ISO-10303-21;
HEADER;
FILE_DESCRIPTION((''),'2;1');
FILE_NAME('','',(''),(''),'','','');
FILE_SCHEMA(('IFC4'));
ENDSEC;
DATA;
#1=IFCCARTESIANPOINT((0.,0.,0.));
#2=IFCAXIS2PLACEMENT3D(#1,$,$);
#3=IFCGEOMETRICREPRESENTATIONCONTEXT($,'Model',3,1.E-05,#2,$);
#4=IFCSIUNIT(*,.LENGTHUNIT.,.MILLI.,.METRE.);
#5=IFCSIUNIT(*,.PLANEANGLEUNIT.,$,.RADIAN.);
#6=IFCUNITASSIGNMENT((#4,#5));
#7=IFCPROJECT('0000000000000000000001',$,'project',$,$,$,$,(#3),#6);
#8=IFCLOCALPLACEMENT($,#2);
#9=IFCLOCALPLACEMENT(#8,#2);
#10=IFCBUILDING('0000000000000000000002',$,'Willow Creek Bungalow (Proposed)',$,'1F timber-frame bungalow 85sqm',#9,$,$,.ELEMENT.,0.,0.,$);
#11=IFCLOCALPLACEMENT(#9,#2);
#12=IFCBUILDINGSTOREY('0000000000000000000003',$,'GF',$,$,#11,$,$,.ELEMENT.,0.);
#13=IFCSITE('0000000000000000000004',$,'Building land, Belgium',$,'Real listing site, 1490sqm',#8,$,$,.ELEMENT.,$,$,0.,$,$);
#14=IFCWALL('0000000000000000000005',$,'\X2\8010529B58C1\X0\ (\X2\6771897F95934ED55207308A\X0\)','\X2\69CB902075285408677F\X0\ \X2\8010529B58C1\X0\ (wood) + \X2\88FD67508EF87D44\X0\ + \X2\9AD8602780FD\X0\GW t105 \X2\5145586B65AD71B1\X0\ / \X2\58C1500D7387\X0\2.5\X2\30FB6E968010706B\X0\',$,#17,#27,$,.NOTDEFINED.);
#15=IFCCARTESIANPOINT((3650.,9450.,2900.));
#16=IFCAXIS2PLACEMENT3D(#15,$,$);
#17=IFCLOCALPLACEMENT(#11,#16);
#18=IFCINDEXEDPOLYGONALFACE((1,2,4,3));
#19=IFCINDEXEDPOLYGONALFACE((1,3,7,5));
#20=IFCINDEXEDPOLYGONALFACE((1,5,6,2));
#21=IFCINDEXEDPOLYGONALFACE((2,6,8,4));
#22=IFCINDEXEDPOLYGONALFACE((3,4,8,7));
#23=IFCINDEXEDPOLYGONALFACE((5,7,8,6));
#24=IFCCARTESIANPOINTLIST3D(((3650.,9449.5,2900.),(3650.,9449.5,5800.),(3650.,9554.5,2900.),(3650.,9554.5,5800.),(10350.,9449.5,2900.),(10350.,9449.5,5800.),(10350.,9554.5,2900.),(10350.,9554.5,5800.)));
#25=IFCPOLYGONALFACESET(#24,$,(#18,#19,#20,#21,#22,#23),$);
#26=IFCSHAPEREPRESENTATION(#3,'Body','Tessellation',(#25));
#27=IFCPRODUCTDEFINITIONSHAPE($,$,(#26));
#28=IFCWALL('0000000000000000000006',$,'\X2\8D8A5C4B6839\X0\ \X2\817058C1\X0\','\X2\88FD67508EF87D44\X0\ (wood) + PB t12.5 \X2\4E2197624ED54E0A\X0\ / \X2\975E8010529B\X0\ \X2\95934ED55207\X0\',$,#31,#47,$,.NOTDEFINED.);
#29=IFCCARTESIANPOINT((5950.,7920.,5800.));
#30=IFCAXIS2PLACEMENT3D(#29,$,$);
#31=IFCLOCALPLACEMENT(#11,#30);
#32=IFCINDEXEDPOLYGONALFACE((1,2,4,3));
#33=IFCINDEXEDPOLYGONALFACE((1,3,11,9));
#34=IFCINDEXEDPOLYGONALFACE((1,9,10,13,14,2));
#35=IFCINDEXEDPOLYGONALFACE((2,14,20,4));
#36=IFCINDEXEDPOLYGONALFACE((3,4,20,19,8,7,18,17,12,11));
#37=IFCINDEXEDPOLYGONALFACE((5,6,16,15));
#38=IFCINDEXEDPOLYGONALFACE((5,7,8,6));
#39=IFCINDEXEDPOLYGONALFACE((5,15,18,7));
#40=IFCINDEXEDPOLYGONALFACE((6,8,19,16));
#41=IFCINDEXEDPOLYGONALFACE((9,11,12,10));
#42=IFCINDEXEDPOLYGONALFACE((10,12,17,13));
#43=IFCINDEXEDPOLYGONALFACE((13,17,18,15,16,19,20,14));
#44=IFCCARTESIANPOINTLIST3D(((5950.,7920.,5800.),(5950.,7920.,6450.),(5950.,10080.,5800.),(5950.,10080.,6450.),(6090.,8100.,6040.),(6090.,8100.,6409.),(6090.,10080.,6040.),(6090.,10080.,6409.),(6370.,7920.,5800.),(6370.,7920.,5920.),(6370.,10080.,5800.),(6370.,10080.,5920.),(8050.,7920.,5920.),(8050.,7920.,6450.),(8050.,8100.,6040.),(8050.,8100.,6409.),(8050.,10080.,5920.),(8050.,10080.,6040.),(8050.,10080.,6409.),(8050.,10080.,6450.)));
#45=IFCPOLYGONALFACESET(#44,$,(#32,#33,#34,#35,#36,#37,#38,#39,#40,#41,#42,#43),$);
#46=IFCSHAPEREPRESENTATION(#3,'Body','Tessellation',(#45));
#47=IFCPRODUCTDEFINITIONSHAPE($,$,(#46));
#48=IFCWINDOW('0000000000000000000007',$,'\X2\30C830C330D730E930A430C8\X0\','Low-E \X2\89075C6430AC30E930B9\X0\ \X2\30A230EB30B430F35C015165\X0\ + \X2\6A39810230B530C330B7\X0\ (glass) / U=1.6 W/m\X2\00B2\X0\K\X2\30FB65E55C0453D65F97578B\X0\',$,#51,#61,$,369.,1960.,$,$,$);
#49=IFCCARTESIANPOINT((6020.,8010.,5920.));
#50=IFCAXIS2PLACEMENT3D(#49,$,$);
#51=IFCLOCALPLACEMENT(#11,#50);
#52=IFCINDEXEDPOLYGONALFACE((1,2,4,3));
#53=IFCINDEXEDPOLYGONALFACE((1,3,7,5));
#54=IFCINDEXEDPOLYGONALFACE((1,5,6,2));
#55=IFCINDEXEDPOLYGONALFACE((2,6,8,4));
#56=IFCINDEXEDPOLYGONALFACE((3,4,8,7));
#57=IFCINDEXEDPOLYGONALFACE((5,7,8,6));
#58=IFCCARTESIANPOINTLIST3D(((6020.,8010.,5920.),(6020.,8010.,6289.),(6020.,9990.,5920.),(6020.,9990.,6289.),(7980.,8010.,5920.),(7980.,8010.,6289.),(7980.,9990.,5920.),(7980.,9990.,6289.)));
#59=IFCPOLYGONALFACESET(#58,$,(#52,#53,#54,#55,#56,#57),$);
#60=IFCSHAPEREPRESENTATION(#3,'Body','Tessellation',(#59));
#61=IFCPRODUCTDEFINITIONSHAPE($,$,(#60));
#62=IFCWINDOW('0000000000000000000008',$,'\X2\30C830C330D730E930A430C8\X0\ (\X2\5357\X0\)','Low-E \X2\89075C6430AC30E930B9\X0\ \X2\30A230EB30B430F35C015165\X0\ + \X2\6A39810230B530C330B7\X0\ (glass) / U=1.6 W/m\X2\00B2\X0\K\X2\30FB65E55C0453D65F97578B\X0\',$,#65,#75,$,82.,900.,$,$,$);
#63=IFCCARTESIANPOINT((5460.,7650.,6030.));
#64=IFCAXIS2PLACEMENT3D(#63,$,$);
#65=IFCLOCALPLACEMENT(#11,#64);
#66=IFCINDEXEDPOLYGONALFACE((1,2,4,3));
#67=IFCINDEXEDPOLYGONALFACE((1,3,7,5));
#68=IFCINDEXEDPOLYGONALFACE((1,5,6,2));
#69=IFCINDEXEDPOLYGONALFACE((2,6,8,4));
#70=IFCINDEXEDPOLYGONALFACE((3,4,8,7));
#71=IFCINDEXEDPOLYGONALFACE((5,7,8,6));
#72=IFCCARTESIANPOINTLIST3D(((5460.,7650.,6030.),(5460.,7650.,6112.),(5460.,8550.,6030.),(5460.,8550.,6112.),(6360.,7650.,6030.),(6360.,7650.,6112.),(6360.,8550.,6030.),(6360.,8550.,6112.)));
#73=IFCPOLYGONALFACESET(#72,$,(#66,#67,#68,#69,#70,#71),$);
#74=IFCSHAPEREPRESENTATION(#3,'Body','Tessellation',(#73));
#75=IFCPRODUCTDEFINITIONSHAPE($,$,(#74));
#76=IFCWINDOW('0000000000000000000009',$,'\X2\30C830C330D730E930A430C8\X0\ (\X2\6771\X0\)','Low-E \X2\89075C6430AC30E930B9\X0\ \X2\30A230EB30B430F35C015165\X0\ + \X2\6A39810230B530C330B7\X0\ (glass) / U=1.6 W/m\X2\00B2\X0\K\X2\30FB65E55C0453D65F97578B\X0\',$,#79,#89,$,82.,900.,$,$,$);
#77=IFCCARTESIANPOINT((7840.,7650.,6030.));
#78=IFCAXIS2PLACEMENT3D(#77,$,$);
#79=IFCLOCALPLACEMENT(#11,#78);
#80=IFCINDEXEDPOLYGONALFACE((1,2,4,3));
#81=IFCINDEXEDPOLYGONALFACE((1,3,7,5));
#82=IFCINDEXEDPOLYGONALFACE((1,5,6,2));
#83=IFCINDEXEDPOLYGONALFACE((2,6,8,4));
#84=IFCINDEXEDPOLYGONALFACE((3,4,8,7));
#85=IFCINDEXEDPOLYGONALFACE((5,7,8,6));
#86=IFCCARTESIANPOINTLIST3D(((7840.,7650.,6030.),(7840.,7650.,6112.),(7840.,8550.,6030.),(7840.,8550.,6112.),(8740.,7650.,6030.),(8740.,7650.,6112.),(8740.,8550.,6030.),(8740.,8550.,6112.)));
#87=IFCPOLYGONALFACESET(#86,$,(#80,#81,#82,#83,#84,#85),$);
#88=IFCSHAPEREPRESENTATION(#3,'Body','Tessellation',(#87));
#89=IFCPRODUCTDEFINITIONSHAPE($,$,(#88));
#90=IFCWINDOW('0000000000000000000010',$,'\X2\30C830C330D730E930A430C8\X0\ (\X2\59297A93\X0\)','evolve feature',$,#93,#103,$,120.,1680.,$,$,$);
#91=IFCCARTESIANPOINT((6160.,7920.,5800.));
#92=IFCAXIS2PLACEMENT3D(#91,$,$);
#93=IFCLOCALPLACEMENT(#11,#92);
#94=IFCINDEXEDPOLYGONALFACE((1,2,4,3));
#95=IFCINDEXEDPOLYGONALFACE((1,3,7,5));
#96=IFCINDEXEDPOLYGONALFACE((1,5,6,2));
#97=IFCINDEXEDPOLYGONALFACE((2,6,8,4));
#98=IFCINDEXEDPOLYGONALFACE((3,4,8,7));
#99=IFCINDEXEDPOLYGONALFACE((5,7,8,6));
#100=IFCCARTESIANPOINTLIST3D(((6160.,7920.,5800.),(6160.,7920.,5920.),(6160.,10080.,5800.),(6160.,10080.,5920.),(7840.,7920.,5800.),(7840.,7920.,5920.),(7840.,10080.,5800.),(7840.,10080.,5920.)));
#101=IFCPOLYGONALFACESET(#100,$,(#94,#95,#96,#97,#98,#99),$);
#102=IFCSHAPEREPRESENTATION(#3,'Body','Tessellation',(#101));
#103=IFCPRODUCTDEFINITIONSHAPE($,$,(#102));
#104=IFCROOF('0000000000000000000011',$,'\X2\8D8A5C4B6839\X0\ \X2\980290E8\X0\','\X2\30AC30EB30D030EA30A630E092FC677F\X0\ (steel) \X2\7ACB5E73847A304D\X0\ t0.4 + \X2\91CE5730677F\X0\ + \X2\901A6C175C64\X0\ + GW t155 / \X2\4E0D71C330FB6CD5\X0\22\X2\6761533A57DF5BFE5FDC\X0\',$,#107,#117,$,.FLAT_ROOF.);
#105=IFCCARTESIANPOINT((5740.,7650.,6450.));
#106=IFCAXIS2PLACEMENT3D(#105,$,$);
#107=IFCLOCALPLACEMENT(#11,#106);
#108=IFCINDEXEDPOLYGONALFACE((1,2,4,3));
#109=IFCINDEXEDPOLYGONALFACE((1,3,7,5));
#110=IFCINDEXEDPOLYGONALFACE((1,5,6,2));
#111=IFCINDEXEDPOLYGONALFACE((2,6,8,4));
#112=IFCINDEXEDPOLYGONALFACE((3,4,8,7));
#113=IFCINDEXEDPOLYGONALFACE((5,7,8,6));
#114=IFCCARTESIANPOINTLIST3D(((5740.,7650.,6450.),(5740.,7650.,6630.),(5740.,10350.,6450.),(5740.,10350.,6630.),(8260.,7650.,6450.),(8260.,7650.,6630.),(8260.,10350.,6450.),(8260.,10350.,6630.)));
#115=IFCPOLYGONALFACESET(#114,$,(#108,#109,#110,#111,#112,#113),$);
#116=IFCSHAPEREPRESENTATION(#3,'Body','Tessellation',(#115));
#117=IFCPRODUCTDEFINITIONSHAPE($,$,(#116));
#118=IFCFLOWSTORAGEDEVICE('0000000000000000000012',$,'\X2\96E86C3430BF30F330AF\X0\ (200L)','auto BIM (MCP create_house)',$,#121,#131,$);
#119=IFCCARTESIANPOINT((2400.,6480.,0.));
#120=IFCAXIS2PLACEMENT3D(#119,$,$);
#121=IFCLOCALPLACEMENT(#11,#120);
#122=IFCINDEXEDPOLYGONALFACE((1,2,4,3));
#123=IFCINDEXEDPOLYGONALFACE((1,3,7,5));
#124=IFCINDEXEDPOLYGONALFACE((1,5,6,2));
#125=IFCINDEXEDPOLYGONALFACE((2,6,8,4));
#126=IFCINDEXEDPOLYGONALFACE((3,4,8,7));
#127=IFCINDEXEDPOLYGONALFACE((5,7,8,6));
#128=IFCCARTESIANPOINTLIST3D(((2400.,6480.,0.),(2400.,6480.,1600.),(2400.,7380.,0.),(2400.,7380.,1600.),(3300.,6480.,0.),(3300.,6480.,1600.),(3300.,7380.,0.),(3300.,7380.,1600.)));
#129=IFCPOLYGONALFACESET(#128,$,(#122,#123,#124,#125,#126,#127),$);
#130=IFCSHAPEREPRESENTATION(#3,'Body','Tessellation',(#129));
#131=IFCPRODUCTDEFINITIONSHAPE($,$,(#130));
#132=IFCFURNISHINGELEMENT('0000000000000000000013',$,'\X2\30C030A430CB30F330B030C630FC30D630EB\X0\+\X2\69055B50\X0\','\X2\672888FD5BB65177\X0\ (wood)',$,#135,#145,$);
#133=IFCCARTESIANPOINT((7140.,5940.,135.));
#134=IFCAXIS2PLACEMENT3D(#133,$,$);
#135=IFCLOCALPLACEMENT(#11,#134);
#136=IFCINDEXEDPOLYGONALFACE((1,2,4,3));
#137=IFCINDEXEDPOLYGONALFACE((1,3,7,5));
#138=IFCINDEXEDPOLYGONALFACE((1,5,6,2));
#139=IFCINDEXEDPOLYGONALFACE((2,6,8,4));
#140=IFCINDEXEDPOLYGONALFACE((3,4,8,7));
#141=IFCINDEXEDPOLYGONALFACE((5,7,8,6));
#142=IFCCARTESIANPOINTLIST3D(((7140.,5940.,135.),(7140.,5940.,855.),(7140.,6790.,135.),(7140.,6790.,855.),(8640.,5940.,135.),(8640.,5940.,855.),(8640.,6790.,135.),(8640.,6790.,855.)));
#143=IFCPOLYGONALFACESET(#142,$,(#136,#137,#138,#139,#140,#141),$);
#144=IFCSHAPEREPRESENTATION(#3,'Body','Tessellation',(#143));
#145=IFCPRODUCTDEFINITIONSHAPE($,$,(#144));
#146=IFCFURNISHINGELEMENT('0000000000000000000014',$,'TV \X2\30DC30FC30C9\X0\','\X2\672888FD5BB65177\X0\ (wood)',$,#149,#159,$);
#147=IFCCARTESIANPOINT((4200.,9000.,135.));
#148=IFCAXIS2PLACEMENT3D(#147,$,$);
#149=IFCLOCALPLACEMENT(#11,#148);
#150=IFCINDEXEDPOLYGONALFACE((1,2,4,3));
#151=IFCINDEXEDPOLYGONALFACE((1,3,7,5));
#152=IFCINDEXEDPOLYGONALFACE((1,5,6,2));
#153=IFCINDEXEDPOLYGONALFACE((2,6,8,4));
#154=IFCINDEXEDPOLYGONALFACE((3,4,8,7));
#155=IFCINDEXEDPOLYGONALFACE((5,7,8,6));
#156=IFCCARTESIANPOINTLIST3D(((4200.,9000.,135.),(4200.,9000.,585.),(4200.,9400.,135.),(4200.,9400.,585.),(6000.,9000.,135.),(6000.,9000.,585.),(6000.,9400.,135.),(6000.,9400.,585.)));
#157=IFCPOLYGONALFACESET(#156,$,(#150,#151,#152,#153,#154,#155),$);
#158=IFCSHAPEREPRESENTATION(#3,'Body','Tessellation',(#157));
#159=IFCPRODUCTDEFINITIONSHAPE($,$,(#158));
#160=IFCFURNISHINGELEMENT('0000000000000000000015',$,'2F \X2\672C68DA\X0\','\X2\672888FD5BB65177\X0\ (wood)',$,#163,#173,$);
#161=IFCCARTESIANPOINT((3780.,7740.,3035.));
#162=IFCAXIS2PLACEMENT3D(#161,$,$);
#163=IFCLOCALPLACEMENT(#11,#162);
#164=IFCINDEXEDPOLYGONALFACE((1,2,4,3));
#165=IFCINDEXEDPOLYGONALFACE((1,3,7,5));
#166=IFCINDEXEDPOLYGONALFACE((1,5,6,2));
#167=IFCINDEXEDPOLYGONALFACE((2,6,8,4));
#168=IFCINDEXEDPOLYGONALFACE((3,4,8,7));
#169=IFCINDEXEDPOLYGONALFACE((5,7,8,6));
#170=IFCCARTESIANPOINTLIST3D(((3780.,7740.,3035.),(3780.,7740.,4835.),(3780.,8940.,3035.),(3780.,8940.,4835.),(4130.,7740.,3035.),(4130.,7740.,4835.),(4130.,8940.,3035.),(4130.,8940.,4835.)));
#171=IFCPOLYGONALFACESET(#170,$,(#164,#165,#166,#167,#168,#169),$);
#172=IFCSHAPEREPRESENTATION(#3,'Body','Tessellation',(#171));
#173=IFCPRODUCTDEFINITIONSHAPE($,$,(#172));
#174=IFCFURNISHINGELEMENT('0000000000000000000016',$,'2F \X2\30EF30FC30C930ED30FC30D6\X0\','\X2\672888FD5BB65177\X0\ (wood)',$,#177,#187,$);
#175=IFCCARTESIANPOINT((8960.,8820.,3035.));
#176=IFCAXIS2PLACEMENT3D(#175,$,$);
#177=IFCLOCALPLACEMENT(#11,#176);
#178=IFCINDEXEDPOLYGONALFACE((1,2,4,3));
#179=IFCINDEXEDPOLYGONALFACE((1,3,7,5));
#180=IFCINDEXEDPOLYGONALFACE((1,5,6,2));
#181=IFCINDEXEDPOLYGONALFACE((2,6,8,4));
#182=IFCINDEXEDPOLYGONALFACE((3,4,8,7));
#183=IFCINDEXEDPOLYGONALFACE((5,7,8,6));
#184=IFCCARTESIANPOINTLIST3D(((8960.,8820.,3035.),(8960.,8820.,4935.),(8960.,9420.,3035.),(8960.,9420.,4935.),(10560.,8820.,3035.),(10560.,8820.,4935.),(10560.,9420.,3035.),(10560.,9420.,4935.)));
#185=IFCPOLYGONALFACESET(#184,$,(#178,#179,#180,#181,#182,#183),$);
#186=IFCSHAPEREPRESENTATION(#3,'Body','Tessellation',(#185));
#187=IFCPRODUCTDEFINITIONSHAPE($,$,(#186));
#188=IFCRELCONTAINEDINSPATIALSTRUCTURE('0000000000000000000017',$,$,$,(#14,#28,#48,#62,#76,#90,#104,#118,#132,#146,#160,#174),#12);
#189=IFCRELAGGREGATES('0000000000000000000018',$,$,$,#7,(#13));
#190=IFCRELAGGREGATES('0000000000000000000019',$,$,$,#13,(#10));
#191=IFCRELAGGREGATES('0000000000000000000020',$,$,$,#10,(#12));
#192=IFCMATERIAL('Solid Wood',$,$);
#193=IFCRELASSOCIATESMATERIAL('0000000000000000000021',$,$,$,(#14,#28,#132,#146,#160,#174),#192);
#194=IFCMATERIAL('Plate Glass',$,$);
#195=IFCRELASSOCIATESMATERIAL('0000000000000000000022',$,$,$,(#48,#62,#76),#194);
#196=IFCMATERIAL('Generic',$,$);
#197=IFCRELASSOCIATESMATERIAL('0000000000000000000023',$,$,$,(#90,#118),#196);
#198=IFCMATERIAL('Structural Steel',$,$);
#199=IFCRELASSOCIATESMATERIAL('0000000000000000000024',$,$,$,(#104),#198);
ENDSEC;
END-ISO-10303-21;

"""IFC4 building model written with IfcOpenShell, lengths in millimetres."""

from ifc_helpers import new_model, si_unit, frame, frame_2d, origin, place, context, project, spatial, rectangle, extrude, material, element, fill, save


model = new_model("IFC4")

# Units and contexts
model_context = context("Model", 3, precision=1e-05, world=origin())
ifc_project = project(units=[si_unit("LENGTHUNIT", "METRE", prefix="MILLI"), si_unit("PLANEANGLEUNIT", "RADIAN")], contexts=[model_context])

# Site, building, storey
site_placement = place(None, origin())
site = spatial("IfcSite", under=ifc_project, at=site_placement, Name="Building land, Belgium", ObjectType="Real listing site, 1490sqm", CompositionType="ELEMENT", RefElevation=0.0)
building_placement = place(site_placement, origin())
building = spatial("IfcBuilding", under=site, at=building_placement, Name="Willow Creek Bungalow (Proposed)", ObjectType="1F timber-frame bungalow 85sqm", CompositionType="ELEMENT", ElevationOfRefHeight=0.0, ElevationOfTerrain=0.0)
storey_placement = place(building_placement, origin())
storey = spatial("IfcBuildingStorey", under=building, at=storey_placement, Name="GF", CompositionType="ELEMENT", Elevation=0.0)

# Wall
ifc_material_1 = material(Name="Solid Wood")
wall_1_placement = place(storey_placement, frame((3650.0, 9450.0, 2900.0)))
element("IfcWall", 1, at=wall_1_placement, inside=storey, material=ifc_material_1, Name="耐力壁 (東西間仕切り)", Description="構造用合板 耐力壁 (wood) + 製材軸組 + 高性能GW t105 充填断熱 / 壁倍率2.5・準耐火", PredefinedType="NOTDEFINED", context=model_context, shape_type="SweptSolid", body=[
    extrude(rectangle(XDim=6700.0, YDim=105.0, at=frame_2d((3350.0, 52.0))), frame((3650.0, 9450.0, 2900.0)), (0.0, 0.0, 1.0), 2900.0),
])

# Wall, openings, windows
wall_2_placement = place(storey_placement, frame((5950.0, 7920.0, 5800.0)))
wall_2 = element("IfcWall", 2, at=wall_2_placement, inside=storey, material=ifc_material_1, Name="越屋根 腰壁", Description="製材軸組 (wood) + PB t12.5 両面仕上 / 非耐力 間仕切", PredefinedType="NOTDEFINED", context=model_context, shape_type="SweptSolid", body=[
    extrude(rectangle(XDim=2100.0, YDim=2160.0, at=frame_2d((1050.0, 1080.0))), frame((5950.0, 7920.0, 5800.0)), (0.0, 0.0, 1.0), 650.0),
])
opening_1_placement = place(storey_placement, frame((6020.0, 8010.0, 5920.0)))
opening_1 = element("IfcOpeningElement", 3, at=opening_1_placement, cuts=wall_2, PredefinedType="NOTDEFINED", context=model_context, shape_type="SweptSolid", body=[
    extrude(rectangle(XDim=1960.0, YDim=1980.0, at=frame_2d((980.0, 990.0))), frame((6020.0, 8010.0, 5920.0)), (0.0, 0.0, 1.0), 369.0),
])
opening_2_placement = place(storey_placement, frame((5460.0, 7650.0, 6030.0)))
opening_2 = element("IfcOpeningElement", 4, at=opening_2_placement, cuts=wall_2, PredefinedType="NOTDEFINED", context=model_context, shape_type="SweptSolid", body=[
    extrude(rectangle(XDim=900.0, YDim=900.0, at=frame_2d((450.0, 450.0))), frame((5460.0, 7650.0, 6030.0)), (0.0, 0.0, 1.0), 82.0),
])
opening_3_placement = place(storey_placement, frame((7840.0, 7650.0, 6030.0)))
opening_3 = element("IfcOpeningElement", 5, at=opening_3_placement, cuts=wall_2, PredefinedType="NOTDEFINED", context=model_context, shape_type="SweptSolid", body=[
    extrude(rectangle(XDim=900.0, YDim=900.0, at=frame_2d((450.0, 450.0))), frame((7840.0, 7650.0, 6030.0)), (0.0, 0.0, 1.0), 82.0),
])
opening_4_placement = place(storey_placement, frame((6160.0, 7920.0, 5800.0)))
opening_4 = element("IfcOpeningElement", 6, at=opening_4_placement, cuts=wall_2, PredefinedType="NOTDEFINED", context=model_context, shape_type="SweptSolid", body=[
    extrude(rectangle(XDim=1680.0, YDim=2160.0, at=frame_2d((840.0, 1080.0))), frame((6160.0, 7920.0, 5800.0)), (0.0, 0.0, 1.0), 120.0),
])
ifc_material_2 = material(Name="Plate Glass")
window_1_placement = place(storey_placement, frame((6020.0, 8010.0, 5920.0)))
window_1 = element("IfcWindow", 7, at=window_1_placement, inside=storey, material=ifc_material_2, Name="トップライト", Description="Low-E 複層ガラス アルゴン封入 + 樹脂サッシ (glass) / U=1.6 W/m²K・日射取得型", OverallHeight=369.0, OverallWidth=1960.0, context=model_context, shape_type="SweptSolid", body=[
    extrude(rectangle(XDim=1960.0, YDim=1980.0, at=frame_2d((980.0, 990.0))), frame((6020.0, 8010.0, 5920.0)), (0.0, 0.0, 1.0), 369.0),
])
fill(opening_1, window_1)
window_2_placement = place(storey_placement, frame((5460.0, 7650.0, 6030.0)))
window_2 = element("IfcWindow", 8, at=window_2_placement, inside=storey, material=ifc_material_2, Name="トップライト (南)", Description="Low-E 複層ガラス アルゴン封入 + 樹脂サッシ (glass) / U=1.6 W/m²K・日射取得型", OverallHeight=82.0, OverallWidth=900.0, context=model_context, shape_type="SweptSolid", body=[
    extrude(rectangle(XDim=900.0, YDim=900.0, at=frame_2d((450.0, 450.0))), frame((5460.0, 7650.0, 6030.0)), (0.0, 0.0, 1.0), 82.0),
])
fill(opening_2, window_2)
window_3_placement = place(storey_placement, frame((7840.0, 7650.0, 6030.0)))
window_3 = element("IfcWindow", 9, at=window_3_placement, inside=storey, material=ifc_material_2, Name="トップライト (東)", Description="Low-E 複層ガラス アルゴン封入 + 樹脂サッシ (glass) / U=1.6 W/m²K・日射取得型", OverallHeight=82.0, OverallWidth=900.0, context=model_context, shape_type="SweptSolid", body=[
    extrude(rectangle(XDim=900.0, YDim=900.0, at=frame_2d((450.0, 450.0))), frame((7840.0, 7650.0, 6030.0)), (0.0, 0.0, 1.0), 82.0),
])
fill(opening_3, window_3)
ifc_material_3 = material(Name="Generic")
window_4_placement = place(storey_placement, frame((6160.0, 7920.0, 5800.0)))
window_4 = element("IfcWindow", 10, at=window_4_placement, inside=storey, material=ifc_material_3, Name="トップライト (天窓)", Description="evolve feature", OverallHeight=120.0, OverallWidth=1680.0, context=model_context, shape_type="SweptSolid", body=[
    extrude(rectangle(XDim=1680.0, YDim=2160.0, at=frame_2d((840.0, 1080.0))), frame((6160.0, 7920.0, 5800.0)), (0.0, 0.0, 1.0), 120.0),
])
fill(opening_4, window_4)

# Roof
ifc_material_4 = material(Name="Structural Steel")
roof_placement = place(storey_placement, frame((5740.0, 7650.0, 6450.0)))
element("IfcRoof", 11, at=roof_placement, inside=storey, material=ifc_material_4, Name="越屋根 頂部", Description="ガルバリウム鋼板 (steel) 立平葺き t0.4 + 野地板 + 通気層 + GW t155 / 不燃・法22条区域対応", PredefinedType="FLAT_ROOF", context=model_context, shape_type="SweptSolid", body=[
    extrude(rectangle(XDim=2520.0, YDim=2700.0, at=frame_2d((1260.0, 1350.0))), frame((5740.0, 7650.0, 6450.0)), (0.0, 0.0, 1.0), 180.0),
])

# Flow storage device
flow_storage_device_placement = place(storey_placement, frame((2400.0, 6480.0, 0.0)))
element("IfcFlowStorageDevice", 12, at=flow_storage_device_placement, inside=storey, material=ifc_material_3, Name="雨水タンク (200L)", Description="auto BIM (MCP create_house)", context=model_context, shape_type="SweptSolid", body=[
    extrude(rectangle(XDim=900.0, YDim=900.0, at=frame_2d((450.0, 450.0))), frame((2400.0, 6480.0, 0.0)), (0.0, 0.0, 1.0), 1600.0),
])

# Furnishing elements
furnishing_1_placement = place(storey_placement, frame((7140.0, 5940.0, 135.0)))
element("IfcFurnishingElement", 13, at=furnishing_1_placement, inside=storey, material=ifc_material_1, Name="ダイニングテーブル+椅子", Description="木製家具 (wood)", context=model_context, shape_type="SweptSolid", body=[
    extrude(rectangle(XDim=1500.0, YDim=850.0, at=frame_2d((750.0, 425.0))), frame((7140.0, 5940.0, 135.0)), (0.0, 0.0, 1.0), 720.0),
])
furnishing_2_placement = place(storey_placement, frame((4200.0, 9000.0, 135.0)))
element("IfcFurnishingElement", 14, at=furnishing_2_placement, inside=storey, material=ifc_material_1, Name="TV ボード", Description="木製家具 (wood)", context=model_context, shape_type="SweptSolid", body=[
    extrude(rectangle(XDim=1800.0, YDim=400.0, at=frame_2d((900.0, 200.0))), frame((4200.0, 9000.0, 135.0)), (0.0, 0.0, 1.0), 450.0),
])
furnishing_3_placement = place(storey_placement, frame((3780.0, 7740.0, 3035.0)))
element("IfcFurnishingElement", 15, at=furnishing_3_placement, inside=storey, material=ifc_material_1, Name="2F 本棚", Description="木製家具 (wood)", context=model_context, shape_type="SweptSolid", body=[
    extrude(rectangle(XDim=350.0, YDim=1200.0, at=frame_2d((175.0, 600.0))), frame((3780.0, 7740.0, 3035.0)), (0.0, 0.0, 1.0), 1800.0),
])
furnishing_4_placement = place(storey_placement, frame((8960.0, 8820.0, 3035.0)))
element("IfcFurnishingElement", 16, at=furnishing_4_placement, inside=storey, material=ifc_material_1, Name="2F ワードローブ", Description="木製家具 (wood)", context=model_context, shape_type="SweptSolid", body=[
    extrude(rectangle(XDim=1600.0, YDim=600.0, at=frame_2d((800.0, 300.0))), frame((8960.0, 8820.0, 3035.0)), (0.0, 0.0, 1.0), 1900.0),
])

save(model, "model.ifc")
